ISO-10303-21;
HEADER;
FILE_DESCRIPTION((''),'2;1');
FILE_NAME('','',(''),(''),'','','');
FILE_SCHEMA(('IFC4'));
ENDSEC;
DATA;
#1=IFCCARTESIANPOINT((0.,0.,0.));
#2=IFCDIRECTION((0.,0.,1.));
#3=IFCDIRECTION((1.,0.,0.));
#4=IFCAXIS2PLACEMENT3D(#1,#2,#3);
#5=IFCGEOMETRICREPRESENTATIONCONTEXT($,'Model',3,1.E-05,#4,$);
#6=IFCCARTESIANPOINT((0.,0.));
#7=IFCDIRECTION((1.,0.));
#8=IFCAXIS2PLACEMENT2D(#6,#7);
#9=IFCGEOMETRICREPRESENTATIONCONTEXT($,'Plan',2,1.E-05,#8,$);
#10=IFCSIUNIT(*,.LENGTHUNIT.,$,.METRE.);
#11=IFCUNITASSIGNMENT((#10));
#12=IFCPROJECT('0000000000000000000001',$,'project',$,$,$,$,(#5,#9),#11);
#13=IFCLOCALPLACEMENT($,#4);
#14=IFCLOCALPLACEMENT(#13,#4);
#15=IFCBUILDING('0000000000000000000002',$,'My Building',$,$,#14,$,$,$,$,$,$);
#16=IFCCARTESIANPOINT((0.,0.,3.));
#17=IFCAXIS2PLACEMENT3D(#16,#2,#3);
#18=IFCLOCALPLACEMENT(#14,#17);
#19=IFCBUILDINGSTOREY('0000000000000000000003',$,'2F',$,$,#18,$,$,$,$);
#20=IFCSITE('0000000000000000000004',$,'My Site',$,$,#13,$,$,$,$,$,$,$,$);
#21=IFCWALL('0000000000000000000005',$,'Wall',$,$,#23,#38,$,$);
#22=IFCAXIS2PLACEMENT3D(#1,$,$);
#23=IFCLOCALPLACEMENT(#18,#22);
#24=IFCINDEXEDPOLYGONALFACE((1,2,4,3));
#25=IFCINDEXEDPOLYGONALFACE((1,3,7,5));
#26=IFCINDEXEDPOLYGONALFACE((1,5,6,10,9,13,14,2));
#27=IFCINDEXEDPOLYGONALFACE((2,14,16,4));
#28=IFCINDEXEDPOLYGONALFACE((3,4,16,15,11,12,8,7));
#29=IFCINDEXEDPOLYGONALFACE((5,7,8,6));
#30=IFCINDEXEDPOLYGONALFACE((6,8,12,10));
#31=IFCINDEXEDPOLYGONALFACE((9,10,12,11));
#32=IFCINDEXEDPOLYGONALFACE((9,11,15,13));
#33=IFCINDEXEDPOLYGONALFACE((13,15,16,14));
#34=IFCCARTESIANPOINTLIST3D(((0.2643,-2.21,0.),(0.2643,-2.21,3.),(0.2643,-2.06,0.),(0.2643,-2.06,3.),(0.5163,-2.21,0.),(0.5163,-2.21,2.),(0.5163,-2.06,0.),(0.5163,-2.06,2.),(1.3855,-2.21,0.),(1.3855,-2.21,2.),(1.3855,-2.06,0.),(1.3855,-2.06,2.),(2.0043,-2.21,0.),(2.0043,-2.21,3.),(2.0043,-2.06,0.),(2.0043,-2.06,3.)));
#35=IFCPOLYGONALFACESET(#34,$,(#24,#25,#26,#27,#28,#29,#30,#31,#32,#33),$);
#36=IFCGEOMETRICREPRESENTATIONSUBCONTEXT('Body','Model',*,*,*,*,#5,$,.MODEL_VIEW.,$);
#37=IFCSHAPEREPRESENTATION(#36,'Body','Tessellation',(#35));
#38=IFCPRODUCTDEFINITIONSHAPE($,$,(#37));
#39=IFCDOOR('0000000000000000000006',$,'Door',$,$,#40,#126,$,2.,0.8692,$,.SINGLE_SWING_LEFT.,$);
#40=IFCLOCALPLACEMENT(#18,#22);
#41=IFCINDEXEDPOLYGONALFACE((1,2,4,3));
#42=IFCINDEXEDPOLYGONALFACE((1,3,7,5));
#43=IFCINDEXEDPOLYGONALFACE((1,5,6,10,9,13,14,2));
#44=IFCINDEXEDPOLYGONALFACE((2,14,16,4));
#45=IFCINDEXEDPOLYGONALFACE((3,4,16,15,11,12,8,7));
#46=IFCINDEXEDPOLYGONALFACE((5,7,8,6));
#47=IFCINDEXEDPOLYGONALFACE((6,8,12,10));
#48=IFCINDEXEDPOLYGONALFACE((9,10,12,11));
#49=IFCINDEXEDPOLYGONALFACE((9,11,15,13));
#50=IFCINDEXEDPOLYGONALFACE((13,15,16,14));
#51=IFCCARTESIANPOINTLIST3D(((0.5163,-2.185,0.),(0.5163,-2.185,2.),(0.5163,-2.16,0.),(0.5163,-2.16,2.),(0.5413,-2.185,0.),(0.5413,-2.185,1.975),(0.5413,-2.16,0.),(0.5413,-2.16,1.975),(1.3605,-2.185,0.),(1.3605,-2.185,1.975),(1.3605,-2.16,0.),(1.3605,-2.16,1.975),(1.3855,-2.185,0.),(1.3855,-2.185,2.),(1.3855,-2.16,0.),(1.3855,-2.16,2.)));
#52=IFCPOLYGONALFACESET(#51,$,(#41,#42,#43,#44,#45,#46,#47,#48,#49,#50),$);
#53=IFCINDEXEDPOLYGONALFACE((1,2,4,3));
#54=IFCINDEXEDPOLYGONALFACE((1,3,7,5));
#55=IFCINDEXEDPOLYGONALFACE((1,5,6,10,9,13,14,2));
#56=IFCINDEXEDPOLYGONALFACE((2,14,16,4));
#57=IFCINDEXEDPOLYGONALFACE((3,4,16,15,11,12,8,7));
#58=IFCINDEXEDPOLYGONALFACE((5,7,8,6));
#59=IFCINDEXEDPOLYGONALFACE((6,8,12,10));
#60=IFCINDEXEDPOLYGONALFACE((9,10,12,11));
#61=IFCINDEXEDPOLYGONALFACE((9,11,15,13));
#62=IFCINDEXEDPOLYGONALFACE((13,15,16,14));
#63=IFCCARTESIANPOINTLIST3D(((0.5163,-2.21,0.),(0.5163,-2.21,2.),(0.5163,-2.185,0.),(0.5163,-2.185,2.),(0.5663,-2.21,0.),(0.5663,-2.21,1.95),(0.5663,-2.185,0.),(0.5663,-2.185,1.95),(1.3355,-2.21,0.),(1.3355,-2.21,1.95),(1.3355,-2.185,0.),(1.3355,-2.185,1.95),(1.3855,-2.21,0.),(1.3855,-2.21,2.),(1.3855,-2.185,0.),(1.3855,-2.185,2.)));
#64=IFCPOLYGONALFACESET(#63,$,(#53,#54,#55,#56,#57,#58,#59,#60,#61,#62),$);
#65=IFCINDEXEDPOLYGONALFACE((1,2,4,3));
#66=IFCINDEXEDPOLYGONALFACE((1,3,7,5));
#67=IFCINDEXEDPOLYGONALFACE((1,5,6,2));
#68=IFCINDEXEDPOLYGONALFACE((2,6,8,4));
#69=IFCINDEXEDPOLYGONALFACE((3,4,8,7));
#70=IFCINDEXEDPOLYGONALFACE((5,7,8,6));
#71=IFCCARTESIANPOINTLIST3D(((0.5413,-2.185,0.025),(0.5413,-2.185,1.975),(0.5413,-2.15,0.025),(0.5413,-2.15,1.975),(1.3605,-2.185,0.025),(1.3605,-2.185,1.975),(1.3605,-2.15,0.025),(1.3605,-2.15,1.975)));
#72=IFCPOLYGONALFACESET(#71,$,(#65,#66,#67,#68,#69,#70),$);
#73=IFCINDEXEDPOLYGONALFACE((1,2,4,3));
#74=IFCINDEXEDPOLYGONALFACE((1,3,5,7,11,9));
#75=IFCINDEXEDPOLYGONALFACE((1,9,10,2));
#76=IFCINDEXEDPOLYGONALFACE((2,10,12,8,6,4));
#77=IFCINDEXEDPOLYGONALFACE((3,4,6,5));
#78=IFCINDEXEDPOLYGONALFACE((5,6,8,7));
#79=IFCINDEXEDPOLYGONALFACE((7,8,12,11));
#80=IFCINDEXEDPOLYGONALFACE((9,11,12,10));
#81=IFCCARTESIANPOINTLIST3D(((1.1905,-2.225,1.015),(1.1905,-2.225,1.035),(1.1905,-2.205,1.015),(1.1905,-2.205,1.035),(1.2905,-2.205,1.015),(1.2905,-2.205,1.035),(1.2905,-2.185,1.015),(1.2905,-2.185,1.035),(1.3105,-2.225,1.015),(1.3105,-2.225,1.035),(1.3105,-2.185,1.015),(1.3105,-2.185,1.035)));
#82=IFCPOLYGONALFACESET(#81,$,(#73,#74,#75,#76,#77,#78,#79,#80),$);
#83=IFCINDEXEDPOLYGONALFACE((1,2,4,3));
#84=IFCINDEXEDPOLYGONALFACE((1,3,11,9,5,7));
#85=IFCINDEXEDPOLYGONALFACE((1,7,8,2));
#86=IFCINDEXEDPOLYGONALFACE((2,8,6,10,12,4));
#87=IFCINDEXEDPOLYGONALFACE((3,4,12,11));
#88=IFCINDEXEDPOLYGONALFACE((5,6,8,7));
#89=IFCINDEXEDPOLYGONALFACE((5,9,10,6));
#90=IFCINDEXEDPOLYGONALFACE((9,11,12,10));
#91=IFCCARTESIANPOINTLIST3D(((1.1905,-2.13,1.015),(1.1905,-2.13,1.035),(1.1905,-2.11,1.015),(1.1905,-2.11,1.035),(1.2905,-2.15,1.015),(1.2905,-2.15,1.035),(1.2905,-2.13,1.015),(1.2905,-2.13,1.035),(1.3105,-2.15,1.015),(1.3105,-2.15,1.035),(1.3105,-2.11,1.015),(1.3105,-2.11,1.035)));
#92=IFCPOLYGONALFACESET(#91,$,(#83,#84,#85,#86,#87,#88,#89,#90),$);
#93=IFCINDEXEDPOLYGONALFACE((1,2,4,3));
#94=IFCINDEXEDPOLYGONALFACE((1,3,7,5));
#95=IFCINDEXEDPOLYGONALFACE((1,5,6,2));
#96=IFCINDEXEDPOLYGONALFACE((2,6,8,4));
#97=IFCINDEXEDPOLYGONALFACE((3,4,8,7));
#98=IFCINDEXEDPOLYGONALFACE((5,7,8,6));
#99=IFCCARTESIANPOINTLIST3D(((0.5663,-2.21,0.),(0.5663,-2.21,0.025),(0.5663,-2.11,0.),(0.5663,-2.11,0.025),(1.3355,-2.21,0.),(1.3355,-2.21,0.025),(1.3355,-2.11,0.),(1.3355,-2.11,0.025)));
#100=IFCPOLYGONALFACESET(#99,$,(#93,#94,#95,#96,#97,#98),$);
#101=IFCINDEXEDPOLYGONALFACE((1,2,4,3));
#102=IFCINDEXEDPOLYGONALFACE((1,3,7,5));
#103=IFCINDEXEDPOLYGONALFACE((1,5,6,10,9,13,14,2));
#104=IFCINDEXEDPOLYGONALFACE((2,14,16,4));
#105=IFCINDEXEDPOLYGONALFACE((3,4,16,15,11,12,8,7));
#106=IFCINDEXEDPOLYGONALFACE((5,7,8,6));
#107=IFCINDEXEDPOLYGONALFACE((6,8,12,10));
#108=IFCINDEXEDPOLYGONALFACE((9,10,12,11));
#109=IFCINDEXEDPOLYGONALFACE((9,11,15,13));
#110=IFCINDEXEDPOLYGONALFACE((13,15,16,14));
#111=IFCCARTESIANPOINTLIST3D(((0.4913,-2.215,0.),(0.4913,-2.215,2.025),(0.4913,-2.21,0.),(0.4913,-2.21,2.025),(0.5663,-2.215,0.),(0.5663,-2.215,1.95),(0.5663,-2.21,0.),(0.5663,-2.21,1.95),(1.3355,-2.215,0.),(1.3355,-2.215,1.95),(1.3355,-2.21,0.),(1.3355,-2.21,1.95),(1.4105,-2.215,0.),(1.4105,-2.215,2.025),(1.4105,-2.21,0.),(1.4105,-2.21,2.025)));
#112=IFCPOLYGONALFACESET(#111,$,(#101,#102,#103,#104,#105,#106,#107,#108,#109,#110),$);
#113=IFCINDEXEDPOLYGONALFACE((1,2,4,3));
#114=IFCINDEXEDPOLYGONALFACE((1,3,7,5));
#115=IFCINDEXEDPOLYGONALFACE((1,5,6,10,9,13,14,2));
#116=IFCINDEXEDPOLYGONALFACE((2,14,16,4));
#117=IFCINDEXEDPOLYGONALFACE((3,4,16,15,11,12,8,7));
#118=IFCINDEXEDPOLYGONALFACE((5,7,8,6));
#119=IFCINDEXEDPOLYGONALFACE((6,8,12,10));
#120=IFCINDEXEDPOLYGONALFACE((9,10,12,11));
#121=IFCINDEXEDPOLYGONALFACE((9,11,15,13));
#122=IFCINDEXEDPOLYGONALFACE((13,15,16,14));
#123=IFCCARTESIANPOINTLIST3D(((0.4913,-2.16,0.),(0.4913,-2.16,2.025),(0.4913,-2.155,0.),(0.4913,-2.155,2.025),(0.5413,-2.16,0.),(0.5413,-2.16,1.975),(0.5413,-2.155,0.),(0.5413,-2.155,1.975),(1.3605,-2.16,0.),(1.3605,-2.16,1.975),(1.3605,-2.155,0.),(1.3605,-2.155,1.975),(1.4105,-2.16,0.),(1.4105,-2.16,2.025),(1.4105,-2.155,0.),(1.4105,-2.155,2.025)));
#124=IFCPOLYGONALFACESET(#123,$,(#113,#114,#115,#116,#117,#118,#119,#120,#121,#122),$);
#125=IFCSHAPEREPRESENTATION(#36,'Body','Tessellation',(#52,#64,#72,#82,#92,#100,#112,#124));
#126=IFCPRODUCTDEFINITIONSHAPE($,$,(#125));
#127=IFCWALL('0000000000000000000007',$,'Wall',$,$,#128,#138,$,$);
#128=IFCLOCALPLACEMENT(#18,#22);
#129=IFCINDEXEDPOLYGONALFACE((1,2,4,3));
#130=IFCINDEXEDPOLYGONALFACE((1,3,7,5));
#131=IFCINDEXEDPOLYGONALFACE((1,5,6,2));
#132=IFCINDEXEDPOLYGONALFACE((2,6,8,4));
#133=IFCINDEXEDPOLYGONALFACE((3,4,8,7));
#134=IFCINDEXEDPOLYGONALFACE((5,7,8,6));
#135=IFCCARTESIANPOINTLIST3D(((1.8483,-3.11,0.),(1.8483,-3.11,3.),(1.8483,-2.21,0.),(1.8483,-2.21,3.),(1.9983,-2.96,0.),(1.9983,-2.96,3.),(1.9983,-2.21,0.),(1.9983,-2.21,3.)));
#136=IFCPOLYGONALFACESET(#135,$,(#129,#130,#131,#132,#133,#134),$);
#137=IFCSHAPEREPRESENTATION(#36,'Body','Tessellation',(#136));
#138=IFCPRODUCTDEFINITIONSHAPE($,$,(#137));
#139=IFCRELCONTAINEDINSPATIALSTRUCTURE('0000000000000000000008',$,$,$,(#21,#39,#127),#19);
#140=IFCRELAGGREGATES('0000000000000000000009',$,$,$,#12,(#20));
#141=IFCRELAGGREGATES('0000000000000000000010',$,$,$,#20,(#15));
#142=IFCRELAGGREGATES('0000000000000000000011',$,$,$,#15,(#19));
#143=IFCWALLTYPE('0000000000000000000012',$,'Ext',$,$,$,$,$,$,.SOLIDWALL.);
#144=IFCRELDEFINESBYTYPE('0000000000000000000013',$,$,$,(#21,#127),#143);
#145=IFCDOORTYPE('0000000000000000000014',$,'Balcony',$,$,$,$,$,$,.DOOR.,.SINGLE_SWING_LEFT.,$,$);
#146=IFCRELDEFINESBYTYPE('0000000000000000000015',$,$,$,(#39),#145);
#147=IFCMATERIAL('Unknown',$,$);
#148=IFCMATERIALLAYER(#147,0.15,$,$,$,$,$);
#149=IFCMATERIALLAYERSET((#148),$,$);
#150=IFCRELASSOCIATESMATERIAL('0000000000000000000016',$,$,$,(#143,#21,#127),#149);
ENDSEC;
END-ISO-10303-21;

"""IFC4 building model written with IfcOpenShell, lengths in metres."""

from ifc_helpers import new_model, entity, si_unit, frame, origin_with_axes, origin_2d_with_axis, place, context, subcontext, project, spatial, line, indexed_curve, outline, extrude, shape, source, transform, mapped, material, layer, layer_set, layer_usage, type_object, type_shapes, element, fill, save


model = new_model("IFC4")

# Units and contexts
model_context = context("Model", 3, precision=1e-05, world=origin_with_axes())
plan_context = context("Plan", 2, precision=1e-05, world=origin_2d_with_axis())
body_context_1 = subcontext(model_context, "Body", "Model", "MODEL_VIEW")
body_context_2 = subcontext(plan_context, "Body", "Plan", "PLAN_VIEW")
ifc_project = project(units=[si_unit("LENGTHUNIT", "METRE")], contexts=[model_context, plan_context])

# Site, building, storey
site_placement = place(None, origin_with_axes())
site = spatial("IfcSite", under=ifc_project, at=site_placement, Name="My Site")
building_placement = place(site_placement, origin_with_axes())
building = spatial("IfcBuilding", under=site, at=building_placement, Name="My Building")
storey_placement = place(building_placement, frame((0.0, 0.0, 3.0), z_axis=(0.0, 0.0, 1.0), x_axis=(1.0, 0.0, 0.0)))
storey = spatial("IfcBuildingStorey", under=building, at=storey_placement, Name="2F")

# Shared definitions
ifc_material = material(Name="Unknown")

# Wall, opening, door
ifc_layer_1 = layer(ifc_material, 0.15)
ifc_layer_set_1 = layer_set([ifc_layer_1])
ifc_layer_usage_1 = layer_usage(ifc_layer_set_1, "AXIS2", "POSITIVE", 0.0)
wall_type_1 = type_object("IfcWallType", Name="Ext", PredefinedType="SOLIDWALL", material=ifc_layer_set_1)
wall_1_placement = place(storey_placement, frame((0.2643, -2.21, 0.0), z_axis=(0.0, 0.0, 1.0), x_axis=(1.0, 0.0, 0.0)))
wall_1 = element("IfcWall", 1, at=wall_1_placement, inside=storey, type_object=wall_type_1, material=ifc_layer_usage_1, Name="Wall", context=body_context_1, shape_type="SweptSolid", body=[
    extrude(outline(indexed_curve([(0.0, 0.0), (0.0, 0.15), (1.74, 0.15), (1.74, 0.0)], segments=[line(1, 2, 3, 4, 1)])), origin_with_axes(), (0.0, 0.0, 1.0), 3.0),
])
shared_shape_1 = source(origin_with_axes(), body_context_1, "Body", "SweptSolid", [
    extrude(outline(indexed_curve([(0.0, 0.0), (0.8692, 0.0), (0.8692, 2.0), (0.0, 2.0)], segments=[line(1, 2, 3, 4, 1)])), frame((0.0, -0.6, 0.0), z_axis=(0.0, -1.0, 0.0), x_axis=(1.0, 0.0, 0.0)), (0.0, 0.0, -1.0), 1.2),
])
opening_1_placement = place(wall_1_placement, frame((0.252, 0.0, 0.0), z_axis=(0.0, 0.0, 1.0), x_axis=(1.0, 0.0, 0.0)))
opening_1 = element("IfcOpeningElement", 2, at=opening_1_placement, cuts=wall_1, PredefinedType="OPENING", context=body_context_1, shape_type="MappedRepresentation", body=[
    mapped(shared_shape_1, transform((0.0, 0.0, 0.0), x_axis=(1.0, 0.0, 0.0), y_axis=(0.0, 1.0, 0.0), z_axis=(0.0, 0.0, 1.0), scale=1.0)),
])
door_type_1 = type_object("IfcDoorType", Name="Balcony", OperationType="SINGLE_SWING_LEFT", PredefinedType="DOOR")
shared_shape_2 = source(origin_with_axes(), body_context_1, "Body", "SweptSolid", [
    extrude(outline(indexed_curve([(0.0, 0.0), (0.0, 2.0), (0.8692, 2.0), (0.8692, 0.0), (0.8442, 0.0), (0.8442, 1.975), (0.025, 1.975), (0.025, 0.0)], segments=[line(1, 2, 3, 4, 5, 6, 7, 8, 1)])), frame((0.0, 0.025, 0.0), z_axis=(0.0, -1.0, 0.0), x_axis=(1.0, 0.0, 0.0)), (0.0, 0.0, -1.0), 0.025),
    extrude(outline(indexed_curve([(0.0, 0.0), (0.0, 2.0), (0.8692, 2.0), (0.8692, 0.0), (0.8192, 0.0), (0.8192, 1.95), (0.05, 1.95), (0.05, 0.0)], segments=[line(1, 2, 3, 4, 5, 6, 7, 8, 1)])), frame((0.0, 0.0, 0.0), z_axis=(0.0, -1.0, 0.0), x_axis=(1.0, 0.0, 0.0)), (0.0, 0.0, -1.0), 0.025),
    extrude(outline(indexed_curve([(0.0, 0.035), (0.8192, 0.035), (0.8192, 0.0), (0.0, 0.0), (0.0, 0.035)])), frame((0.025, 0.025, 0.025), z_axis=(0.0, 0.0, 1.0), x_axis=(1.0, 0.0, 0.0)), (0.0, 0.0, 1.0), 1.95),
    extrude(outline(indexed_curve([(-0.02, 0.0), (-0.02, -0.02), (-0.12, -0.02), (-0.12, -0.04), (0.0, -0.04), (0.0, 0.0), (-0.02, 0.0)])), frame((0.7942, 0.025, 1.015), z_axis=(0.0, 0.0, 1.0), x_axis=(1.0, 0.0, 0.0)), (0.0, 0.0, 1.0), 0.02),
    extrude(outline(indexed_curve([(0.0, 0.0), (0.0, 0.04), (-0.12, 0.04), (-0.12, 0.02), (-0.02, 0.02), (-0.02, 0.0)], segments=[line(1, 2, 3, 4, 5, 6, 1)])), frame((0.7942, 0.06, 1.015), z_axis=(0.0, 0.0, 1.0), x_axis=(1.0, 0.0, 0.0)), (0.0, 0.0, 1.0), 0.02),
    extrude(outline(indexed_curve([(0.0, 0.1), (0.7692, 0.1), (0.7692, 0.0), (0.0, 0.0), (0.0, 0.1)])), frame((0.05, 0.0, 0.0), z_axis=(0.0, 0.0, 1.0), x_axis=(1.0, 0.0, 0.0)), (0.0, 0.0, 1.0), 0.025),
    extrude(outline(indexed_curve([(0.0, 0.0), (0.0, 2.025), (0.9192, 2.025), (0.9192, 0.0), (0.8442, 0.0), (0.8442, 1.95), (0.075, 1.95), (0.075, 0.0)], segments=[line(1, 2, 3, 4, 5, 6, 7, 8, 1)])), frame((-0.025, -0.005, 0.0), z_axis=(0.0, -1.0, 0.0), x_axis=(1.0, 0.0, 0.0)), (0.0, 0.0, -1.0), 0.005),
    extrude(outline(indexed_curve([(0.05, 0.0), (0.05, 1.975), (0.8692, 1.975), (0.8692, 0.0), (0.9192, 0.0), (0.9192, 2.025), (0.0, 2.025), (0.0, 0.0), (0.05, 0.0)])), frame((-0.025, 0.05, 0.0), z_axis=(0.0, -1.0, 0.0), x_axis=(1.0, 0.0, 0.0)), (0.0, 0.0, -1.0), 0.005),
])
shared_shape_3 = source(origin_with_axes(), body_context_2, "Body", "Curve2D", [
    entity("IfcIndexedPolyCurve", entity("IfcCartesianPointList2D", [[0.0, 0.0], [0.0, 0.05], [0.025, 0.05], [0.025, 0.025], [0.05, 0.025], [0.05, 0.0]]), [entity("IfcLineIndex", [1, 2, 3, 4, 5, 6, 1])]),
    entity("IfcIndexedPolyCurve", entity("IfcCartesianPointList2D", [[0.8692, 0.0], [0.8692, 0.05], [0.8442, 0.05], [0.8442, 0.025], [0.8192, 0.025], [0.8192, 0.0]]), [entity("IfcLineIndex", [1, 2, 3, 4, 5, 6, 1])]),
    entity("IfcTrimmedCurve", entity("IfcEllipse", entity("IfcAxis2Placement2D", entity("IfcCartesianPoint", [0.06, 0.05]), entity("IfcDirection", [1.0, 0.0])), 0.7842, 0.8192), [entity("IfcCartesianPoint", [0.8442, 0.05])], [entity("IfcCartesianPoint", [0.06, 0.8692])], True, "CARTESIAN"),
    entity("IfcIndexedPolyCurve", entity("IfcCartesianPointList2D", [[0.025, 0.05], [0.06, 0.05], [0.06, 0.8692], [0.025, 0.8692]]), [entity("IfcLineIndex", [1, 2, 3, 4, 1])]),
])
type_shapes(door_type_1, [shared_shape_2, shared_shape_3])
door_1_placement = place(opening_1_placement, frame((0.0, 0.0, 0.0), z_axis=(0.0, 0.0, 1.0), x_axis=(1.0, 0.0, 0.0)))
door_1 = element("IfcDoor", 3, at=door_1_placement, inside=storey, type_object=door_type_1, Name="Door", OperationType="SINGLE_SWING_LEFT", OverallHeight=2.0, OverallWidth=0.8692, shapes=[
    shape(body_context_1, "Body", "MappedRepresentation", [mapped(shared_shape_2, transform((0.0, 0.0, 0.0), x_axis=(1.0, 0.0, 0.0), y_axis=(0.0, 1.0, 0.0), z_axis=(0.0, 0.0, 1.0), scale=1.0))]),
    shape(body_context_2, "Body", "MappedRepresentation", [mapped(shared_shape_3, transform((0.0, 0.0, 0.0), x_axis=(1.0, 0.0, 0.0), y_axis=(0.0, 1.0, 0.0), z_axis=(0.0, 0.0, 1.0), scale=1.0))]),
])
fill(opening_1, door_1)

# Wall
ifc_layer_usage_2 = layer_usage(ifc_layer_set_1, "AXIS2", "POSITIVE", 0.0)
wall_2_placement = place(storey_placement, frame((1.8483, -2.21, 0.0), z_axis=(0.0, 0.0, 1.0), x_axis=(0.0, -1.0, 0.0)))
element("IfcWall", 4, at=wall_2_placement, inside=storey, type_object=wall_type_1, material=ifc_layer_usage_2, Name="Wall", context=body_context_1, shape_type="SweptSolid", body=[
    extrude(outline(indexed_curve([(0.0, 0.0), (0.0, 0.15), (0.75, 0.15), (0.9, 0.0)], segments=[line(1, 2, 3, 4, 1)])), origin_with_axes(), (0.0, 0.0, 1.0), 3.0),
])

save(model, "model.ifc")
